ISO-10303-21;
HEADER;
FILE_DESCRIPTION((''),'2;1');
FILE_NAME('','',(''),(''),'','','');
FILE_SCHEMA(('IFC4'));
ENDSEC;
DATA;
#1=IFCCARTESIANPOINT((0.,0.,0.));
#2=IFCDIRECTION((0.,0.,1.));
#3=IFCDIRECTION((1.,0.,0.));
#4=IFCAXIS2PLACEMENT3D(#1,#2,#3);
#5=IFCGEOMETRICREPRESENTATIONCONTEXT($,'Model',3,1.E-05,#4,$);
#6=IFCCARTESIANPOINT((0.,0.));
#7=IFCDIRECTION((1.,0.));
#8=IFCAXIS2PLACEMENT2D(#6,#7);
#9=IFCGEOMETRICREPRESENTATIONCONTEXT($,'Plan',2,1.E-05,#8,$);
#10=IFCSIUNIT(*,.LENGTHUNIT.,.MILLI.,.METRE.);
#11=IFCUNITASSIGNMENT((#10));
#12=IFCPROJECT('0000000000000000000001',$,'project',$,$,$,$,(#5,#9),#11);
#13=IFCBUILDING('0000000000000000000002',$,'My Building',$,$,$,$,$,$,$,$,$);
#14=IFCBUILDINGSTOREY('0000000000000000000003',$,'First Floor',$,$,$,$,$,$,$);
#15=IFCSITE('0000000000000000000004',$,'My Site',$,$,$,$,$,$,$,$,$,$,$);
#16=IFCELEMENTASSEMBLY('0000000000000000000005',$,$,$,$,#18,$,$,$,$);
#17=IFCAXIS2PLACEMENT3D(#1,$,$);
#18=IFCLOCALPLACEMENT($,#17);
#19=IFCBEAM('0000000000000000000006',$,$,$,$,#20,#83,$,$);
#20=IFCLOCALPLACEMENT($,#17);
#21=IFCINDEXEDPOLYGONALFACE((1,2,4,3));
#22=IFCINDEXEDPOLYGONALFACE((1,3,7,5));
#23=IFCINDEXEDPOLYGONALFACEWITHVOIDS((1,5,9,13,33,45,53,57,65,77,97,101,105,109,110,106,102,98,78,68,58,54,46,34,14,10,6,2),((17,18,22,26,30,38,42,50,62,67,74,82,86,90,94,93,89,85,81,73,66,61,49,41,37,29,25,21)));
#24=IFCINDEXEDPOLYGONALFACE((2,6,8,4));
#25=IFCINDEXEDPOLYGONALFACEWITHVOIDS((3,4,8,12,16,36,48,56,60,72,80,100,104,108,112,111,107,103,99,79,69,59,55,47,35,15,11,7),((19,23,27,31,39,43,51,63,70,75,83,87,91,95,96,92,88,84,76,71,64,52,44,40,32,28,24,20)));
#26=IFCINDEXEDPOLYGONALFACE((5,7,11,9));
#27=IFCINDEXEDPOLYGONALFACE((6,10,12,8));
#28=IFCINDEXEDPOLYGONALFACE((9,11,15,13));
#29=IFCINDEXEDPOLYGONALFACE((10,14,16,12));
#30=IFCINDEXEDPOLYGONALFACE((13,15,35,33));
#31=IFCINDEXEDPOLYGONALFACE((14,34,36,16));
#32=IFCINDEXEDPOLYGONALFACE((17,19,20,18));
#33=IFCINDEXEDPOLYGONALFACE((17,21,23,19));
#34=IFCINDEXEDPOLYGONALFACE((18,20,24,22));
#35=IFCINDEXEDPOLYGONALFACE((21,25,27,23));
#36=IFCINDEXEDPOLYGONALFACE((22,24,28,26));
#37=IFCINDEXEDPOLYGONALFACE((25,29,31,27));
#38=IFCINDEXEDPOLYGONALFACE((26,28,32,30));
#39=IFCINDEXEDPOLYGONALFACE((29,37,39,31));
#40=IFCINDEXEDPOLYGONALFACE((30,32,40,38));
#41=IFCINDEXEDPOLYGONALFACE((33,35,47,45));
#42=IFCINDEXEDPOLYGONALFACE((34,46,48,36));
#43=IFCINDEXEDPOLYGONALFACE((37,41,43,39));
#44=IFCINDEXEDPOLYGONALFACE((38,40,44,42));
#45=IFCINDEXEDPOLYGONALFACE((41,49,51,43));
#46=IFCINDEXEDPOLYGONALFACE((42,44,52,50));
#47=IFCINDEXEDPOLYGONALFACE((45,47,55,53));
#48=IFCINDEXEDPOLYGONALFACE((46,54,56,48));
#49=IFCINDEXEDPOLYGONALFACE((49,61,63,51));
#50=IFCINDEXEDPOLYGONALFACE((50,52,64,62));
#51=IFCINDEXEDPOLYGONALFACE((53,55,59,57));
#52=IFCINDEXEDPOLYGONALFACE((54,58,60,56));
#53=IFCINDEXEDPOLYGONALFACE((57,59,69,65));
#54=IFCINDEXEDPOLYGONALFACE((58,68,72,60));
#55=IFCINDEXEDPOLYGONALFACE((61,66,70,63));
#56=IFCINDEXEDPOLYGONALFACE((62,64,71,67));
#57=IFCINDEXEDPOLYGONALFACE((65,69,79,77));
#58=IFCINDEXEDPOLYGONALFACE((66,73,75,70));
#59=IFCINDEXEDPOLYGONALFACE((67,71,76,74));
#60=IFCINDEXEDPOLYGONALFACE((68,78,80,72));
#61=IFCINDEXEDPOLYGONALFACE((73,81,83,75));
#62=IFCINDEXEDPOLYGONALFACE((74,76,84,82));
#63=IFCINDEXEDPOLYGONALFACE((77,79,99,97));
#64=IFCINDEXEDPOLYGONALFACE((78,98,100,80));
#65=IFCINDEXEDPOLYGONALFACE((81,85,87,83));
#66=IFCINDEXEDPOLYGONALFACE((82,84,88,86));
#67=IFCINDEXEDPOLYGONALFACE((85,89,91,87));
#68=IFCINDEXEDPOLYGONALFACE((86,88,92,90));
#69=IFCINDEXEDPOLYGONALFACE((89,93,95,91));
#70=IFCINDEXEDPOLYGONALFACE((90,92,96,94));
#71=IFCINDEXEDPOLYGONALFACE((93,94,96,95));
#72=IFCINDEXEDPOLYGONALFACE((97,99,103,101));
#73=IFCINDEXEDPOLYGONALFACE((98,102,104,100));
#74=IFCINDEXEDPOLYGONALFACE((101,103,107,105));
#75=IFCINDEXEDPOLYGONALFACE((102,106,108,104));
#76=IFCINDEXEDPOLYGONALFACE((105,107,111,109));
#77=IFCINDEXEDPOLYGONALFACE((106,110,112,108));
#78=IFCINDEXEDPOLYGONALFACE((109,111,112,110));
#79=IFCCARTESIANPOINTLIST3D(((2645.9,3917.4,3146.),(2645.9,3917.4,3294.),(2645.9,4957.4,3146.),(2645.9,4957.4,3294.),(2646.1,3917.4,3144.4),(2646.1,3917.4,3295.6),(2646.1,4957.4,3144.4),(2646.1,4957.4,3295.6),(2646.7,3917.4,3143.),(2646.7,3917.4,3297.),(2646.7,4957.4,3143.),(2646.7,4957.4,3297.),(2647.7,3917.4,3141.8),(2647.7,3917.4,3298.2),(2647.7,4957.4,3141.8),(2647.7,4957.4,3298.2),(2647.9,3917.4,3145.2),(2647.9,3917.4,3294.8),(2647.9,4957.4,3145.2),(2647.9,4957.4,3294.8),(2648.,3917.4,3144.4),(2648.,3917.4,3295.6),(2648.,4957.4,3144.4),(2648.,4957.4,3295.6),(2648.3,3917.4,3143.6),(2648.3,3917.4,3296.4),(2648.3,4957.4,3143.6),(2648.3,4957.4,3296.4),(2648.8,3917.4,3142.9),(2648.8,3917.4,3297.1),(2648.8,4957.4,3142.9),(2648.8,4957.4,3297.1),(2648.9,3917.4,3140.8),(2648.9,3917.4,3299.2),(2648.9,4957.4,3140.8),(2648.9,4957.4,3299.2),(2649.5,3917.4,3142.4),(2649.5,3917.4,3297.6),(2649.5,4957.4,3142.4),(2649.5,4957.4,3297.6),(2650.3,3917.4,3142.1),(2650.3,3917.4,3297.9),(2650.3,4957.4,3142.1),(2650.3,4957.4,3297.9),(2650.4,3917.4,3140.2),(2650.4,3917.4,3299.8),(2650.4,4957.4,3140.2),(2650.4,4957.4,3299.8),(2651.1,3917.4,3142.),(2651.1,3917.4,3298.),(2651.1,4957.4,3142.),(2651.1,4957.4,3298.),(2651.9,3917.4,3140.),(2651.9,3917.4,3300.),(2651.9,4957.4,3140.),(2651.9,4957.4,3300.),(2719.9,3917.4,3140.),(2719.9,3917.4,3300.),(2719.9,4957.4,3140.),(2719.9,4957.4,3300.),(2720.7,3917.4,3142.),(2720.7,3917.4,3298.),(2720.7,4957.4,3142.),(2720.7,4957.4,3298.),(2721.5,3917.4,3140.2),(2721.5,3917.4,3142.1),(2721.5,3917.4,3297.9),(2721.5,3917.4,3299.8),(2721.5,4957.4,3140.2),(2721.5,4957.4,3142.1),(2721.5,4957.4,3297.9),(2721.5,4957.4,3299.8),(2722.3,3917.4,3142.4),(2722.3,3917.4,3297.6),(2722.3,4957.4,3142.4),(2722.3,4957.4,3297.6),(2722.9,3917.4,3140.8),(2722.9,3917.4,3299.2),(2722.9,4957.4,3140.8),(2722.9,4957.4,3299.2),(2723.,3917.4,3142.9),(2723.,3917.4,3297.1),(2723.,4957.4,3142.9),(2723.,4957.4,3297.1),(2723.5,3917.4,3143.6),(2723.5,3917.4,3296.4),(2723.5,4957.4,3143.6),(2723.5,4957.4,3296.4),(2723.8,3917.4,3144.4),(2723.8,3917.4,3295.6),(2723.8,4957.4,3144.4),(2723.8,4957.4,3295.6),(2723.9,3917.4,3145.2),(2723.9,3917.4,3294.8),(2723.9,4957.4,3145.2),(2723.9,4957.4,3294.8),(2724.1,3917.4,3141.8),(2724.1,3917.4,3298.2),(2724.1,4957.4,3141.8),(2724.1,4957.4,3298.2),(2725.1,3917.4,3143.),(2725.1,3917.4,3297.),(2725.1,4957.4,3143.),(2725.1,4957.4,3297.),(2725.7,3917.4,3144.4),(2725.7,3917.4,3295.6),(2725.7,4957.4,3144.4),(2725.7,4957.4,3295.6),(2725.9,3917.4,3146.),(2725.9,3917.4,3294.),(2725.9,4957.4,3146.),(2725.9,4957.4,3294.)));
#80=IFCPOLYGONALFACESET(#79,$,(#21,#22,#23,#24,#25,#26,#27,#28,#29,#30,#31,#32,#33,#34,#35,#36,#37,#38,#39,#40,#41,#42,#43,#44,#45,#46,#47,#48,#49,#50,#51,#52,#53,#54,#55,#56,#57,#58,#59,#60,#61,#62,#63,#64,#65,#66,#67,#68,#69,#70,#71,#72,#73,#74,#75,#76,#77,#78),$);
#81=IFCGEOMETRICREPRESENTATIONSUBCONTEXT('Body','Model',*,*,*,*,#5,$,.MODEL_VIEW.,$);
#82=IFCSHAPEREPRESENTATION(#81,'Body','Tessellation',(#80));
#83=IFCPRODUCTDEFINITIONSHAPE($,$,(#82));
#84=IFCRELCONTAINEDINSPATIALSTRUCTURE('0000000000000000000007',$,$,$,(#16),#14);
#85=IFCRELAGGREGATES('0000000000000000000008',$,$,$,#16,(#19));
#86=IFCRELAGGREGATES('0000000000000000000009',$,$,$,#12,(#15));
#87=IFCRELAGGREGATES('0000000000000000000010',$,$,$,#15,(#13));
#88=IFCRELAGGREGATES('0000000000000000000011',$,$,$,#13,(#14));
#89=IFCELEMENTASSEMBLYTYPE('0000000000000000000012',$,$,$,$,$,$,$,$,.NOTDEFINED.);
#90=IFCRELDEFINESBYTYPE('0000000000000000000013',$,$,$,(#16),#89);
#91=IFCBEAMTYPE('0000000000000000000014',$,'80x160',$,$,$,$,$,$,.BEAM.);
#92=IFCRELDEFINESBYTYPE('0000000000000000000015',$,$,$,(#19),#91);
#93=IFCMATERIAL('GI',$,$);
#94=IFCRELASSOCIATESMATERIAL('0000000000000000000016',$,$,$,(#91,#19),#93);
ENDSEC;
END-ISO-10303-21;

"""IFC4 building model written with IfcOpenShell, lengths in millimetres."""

from ifc_helpers import new_model, si_unit, frame, origin_with_axes, origin_2d_with_axis, place, context, subcontext, project, spatial, hollow_rectangle, extrude, material, material_profile, profile_set, profile_usage, type_object, element, aggregate, save


model = new_model("IFC4")

# Units and contexts
model_context = context("Model", 3, precision=1e-05, world=origin_with_axes())
plan_context = context("Plan", 2, precision=1e-05, world=origin_2d_with_axis())
body_context = subcontext(model_context, "Body", "Model", "MODEL_VIEW")
ifc_project = project(units=[si_unit("LENGTHUNIT", "METRE", prefix="MILLI")], contexts=[model_context, plan_context])

# Site, building, storey
site = spatial("IfcSite", under=ifc_project, Name="My Site")
building = spatial("IfcBuilding", under=site, Name="My Building")
storey = spatial("IfcBuildingStorey", under=building, Name="First Floor")

# Element assembly, beam
element_assembly_type = type_object("IfcElementAssemblyType", PredefinedType="NOTDEFINED")
ifc_material = material(Name="GI")
ifc_material_profile = material_profile(ifc_material, hollow_rectangle(XDim=80.0, YDim=160.0, WallThickness=2.0, InnerFilletRadius=3.2, OuterFilletRadius=6.0))
ifc_profile_set = profile_set([ifc_material_profile], Name="80x160 GI Rectangular Hollow")
beam_type = type_object("IfcBeamType", Name="80x160", PredefinedType="BEAM", material=ifc_profile_set)
assembly_1_placement = place(None, frame((2685.9, 3837.4, 3220.0), z_axis=(0.0, 1.0, 0.0), x_axis=(1.0, 0.0, 0.0)))
assembly_1 = element("IfcElementAssembly", 1, at=assembly_1_placement, inside=storey, type_object=element_assembly_type)
ifc_profile_usage_1 = profile_usage(ifc_profile_set)
beam_1_placement = place(assembly_1_placement, frame((0.0, 0.0, 80.0), z_axis=(0.0, 0.0, 1.0), x_axis=(1.0, 0.0, 0.0)))
beam_1 = element("IfcBeam", 2, at=beam_1_placement, type_object=beam_type, material=ifc_profile_usage_1, context=body_context, shape_type="SweptSolid", body=[
    extrude(hollow_rectangle(XDim=80.0, YDim=160.0, WallThickness=2.0, InnerFilletRadius=3.2, OuterFilletRadius=6.0), origin_with_axes(), (0.0, 0.0, 1.0), 1040.0),
])
aggregate(assembly_1, [beam_1])

save(model, "model.ifc")
